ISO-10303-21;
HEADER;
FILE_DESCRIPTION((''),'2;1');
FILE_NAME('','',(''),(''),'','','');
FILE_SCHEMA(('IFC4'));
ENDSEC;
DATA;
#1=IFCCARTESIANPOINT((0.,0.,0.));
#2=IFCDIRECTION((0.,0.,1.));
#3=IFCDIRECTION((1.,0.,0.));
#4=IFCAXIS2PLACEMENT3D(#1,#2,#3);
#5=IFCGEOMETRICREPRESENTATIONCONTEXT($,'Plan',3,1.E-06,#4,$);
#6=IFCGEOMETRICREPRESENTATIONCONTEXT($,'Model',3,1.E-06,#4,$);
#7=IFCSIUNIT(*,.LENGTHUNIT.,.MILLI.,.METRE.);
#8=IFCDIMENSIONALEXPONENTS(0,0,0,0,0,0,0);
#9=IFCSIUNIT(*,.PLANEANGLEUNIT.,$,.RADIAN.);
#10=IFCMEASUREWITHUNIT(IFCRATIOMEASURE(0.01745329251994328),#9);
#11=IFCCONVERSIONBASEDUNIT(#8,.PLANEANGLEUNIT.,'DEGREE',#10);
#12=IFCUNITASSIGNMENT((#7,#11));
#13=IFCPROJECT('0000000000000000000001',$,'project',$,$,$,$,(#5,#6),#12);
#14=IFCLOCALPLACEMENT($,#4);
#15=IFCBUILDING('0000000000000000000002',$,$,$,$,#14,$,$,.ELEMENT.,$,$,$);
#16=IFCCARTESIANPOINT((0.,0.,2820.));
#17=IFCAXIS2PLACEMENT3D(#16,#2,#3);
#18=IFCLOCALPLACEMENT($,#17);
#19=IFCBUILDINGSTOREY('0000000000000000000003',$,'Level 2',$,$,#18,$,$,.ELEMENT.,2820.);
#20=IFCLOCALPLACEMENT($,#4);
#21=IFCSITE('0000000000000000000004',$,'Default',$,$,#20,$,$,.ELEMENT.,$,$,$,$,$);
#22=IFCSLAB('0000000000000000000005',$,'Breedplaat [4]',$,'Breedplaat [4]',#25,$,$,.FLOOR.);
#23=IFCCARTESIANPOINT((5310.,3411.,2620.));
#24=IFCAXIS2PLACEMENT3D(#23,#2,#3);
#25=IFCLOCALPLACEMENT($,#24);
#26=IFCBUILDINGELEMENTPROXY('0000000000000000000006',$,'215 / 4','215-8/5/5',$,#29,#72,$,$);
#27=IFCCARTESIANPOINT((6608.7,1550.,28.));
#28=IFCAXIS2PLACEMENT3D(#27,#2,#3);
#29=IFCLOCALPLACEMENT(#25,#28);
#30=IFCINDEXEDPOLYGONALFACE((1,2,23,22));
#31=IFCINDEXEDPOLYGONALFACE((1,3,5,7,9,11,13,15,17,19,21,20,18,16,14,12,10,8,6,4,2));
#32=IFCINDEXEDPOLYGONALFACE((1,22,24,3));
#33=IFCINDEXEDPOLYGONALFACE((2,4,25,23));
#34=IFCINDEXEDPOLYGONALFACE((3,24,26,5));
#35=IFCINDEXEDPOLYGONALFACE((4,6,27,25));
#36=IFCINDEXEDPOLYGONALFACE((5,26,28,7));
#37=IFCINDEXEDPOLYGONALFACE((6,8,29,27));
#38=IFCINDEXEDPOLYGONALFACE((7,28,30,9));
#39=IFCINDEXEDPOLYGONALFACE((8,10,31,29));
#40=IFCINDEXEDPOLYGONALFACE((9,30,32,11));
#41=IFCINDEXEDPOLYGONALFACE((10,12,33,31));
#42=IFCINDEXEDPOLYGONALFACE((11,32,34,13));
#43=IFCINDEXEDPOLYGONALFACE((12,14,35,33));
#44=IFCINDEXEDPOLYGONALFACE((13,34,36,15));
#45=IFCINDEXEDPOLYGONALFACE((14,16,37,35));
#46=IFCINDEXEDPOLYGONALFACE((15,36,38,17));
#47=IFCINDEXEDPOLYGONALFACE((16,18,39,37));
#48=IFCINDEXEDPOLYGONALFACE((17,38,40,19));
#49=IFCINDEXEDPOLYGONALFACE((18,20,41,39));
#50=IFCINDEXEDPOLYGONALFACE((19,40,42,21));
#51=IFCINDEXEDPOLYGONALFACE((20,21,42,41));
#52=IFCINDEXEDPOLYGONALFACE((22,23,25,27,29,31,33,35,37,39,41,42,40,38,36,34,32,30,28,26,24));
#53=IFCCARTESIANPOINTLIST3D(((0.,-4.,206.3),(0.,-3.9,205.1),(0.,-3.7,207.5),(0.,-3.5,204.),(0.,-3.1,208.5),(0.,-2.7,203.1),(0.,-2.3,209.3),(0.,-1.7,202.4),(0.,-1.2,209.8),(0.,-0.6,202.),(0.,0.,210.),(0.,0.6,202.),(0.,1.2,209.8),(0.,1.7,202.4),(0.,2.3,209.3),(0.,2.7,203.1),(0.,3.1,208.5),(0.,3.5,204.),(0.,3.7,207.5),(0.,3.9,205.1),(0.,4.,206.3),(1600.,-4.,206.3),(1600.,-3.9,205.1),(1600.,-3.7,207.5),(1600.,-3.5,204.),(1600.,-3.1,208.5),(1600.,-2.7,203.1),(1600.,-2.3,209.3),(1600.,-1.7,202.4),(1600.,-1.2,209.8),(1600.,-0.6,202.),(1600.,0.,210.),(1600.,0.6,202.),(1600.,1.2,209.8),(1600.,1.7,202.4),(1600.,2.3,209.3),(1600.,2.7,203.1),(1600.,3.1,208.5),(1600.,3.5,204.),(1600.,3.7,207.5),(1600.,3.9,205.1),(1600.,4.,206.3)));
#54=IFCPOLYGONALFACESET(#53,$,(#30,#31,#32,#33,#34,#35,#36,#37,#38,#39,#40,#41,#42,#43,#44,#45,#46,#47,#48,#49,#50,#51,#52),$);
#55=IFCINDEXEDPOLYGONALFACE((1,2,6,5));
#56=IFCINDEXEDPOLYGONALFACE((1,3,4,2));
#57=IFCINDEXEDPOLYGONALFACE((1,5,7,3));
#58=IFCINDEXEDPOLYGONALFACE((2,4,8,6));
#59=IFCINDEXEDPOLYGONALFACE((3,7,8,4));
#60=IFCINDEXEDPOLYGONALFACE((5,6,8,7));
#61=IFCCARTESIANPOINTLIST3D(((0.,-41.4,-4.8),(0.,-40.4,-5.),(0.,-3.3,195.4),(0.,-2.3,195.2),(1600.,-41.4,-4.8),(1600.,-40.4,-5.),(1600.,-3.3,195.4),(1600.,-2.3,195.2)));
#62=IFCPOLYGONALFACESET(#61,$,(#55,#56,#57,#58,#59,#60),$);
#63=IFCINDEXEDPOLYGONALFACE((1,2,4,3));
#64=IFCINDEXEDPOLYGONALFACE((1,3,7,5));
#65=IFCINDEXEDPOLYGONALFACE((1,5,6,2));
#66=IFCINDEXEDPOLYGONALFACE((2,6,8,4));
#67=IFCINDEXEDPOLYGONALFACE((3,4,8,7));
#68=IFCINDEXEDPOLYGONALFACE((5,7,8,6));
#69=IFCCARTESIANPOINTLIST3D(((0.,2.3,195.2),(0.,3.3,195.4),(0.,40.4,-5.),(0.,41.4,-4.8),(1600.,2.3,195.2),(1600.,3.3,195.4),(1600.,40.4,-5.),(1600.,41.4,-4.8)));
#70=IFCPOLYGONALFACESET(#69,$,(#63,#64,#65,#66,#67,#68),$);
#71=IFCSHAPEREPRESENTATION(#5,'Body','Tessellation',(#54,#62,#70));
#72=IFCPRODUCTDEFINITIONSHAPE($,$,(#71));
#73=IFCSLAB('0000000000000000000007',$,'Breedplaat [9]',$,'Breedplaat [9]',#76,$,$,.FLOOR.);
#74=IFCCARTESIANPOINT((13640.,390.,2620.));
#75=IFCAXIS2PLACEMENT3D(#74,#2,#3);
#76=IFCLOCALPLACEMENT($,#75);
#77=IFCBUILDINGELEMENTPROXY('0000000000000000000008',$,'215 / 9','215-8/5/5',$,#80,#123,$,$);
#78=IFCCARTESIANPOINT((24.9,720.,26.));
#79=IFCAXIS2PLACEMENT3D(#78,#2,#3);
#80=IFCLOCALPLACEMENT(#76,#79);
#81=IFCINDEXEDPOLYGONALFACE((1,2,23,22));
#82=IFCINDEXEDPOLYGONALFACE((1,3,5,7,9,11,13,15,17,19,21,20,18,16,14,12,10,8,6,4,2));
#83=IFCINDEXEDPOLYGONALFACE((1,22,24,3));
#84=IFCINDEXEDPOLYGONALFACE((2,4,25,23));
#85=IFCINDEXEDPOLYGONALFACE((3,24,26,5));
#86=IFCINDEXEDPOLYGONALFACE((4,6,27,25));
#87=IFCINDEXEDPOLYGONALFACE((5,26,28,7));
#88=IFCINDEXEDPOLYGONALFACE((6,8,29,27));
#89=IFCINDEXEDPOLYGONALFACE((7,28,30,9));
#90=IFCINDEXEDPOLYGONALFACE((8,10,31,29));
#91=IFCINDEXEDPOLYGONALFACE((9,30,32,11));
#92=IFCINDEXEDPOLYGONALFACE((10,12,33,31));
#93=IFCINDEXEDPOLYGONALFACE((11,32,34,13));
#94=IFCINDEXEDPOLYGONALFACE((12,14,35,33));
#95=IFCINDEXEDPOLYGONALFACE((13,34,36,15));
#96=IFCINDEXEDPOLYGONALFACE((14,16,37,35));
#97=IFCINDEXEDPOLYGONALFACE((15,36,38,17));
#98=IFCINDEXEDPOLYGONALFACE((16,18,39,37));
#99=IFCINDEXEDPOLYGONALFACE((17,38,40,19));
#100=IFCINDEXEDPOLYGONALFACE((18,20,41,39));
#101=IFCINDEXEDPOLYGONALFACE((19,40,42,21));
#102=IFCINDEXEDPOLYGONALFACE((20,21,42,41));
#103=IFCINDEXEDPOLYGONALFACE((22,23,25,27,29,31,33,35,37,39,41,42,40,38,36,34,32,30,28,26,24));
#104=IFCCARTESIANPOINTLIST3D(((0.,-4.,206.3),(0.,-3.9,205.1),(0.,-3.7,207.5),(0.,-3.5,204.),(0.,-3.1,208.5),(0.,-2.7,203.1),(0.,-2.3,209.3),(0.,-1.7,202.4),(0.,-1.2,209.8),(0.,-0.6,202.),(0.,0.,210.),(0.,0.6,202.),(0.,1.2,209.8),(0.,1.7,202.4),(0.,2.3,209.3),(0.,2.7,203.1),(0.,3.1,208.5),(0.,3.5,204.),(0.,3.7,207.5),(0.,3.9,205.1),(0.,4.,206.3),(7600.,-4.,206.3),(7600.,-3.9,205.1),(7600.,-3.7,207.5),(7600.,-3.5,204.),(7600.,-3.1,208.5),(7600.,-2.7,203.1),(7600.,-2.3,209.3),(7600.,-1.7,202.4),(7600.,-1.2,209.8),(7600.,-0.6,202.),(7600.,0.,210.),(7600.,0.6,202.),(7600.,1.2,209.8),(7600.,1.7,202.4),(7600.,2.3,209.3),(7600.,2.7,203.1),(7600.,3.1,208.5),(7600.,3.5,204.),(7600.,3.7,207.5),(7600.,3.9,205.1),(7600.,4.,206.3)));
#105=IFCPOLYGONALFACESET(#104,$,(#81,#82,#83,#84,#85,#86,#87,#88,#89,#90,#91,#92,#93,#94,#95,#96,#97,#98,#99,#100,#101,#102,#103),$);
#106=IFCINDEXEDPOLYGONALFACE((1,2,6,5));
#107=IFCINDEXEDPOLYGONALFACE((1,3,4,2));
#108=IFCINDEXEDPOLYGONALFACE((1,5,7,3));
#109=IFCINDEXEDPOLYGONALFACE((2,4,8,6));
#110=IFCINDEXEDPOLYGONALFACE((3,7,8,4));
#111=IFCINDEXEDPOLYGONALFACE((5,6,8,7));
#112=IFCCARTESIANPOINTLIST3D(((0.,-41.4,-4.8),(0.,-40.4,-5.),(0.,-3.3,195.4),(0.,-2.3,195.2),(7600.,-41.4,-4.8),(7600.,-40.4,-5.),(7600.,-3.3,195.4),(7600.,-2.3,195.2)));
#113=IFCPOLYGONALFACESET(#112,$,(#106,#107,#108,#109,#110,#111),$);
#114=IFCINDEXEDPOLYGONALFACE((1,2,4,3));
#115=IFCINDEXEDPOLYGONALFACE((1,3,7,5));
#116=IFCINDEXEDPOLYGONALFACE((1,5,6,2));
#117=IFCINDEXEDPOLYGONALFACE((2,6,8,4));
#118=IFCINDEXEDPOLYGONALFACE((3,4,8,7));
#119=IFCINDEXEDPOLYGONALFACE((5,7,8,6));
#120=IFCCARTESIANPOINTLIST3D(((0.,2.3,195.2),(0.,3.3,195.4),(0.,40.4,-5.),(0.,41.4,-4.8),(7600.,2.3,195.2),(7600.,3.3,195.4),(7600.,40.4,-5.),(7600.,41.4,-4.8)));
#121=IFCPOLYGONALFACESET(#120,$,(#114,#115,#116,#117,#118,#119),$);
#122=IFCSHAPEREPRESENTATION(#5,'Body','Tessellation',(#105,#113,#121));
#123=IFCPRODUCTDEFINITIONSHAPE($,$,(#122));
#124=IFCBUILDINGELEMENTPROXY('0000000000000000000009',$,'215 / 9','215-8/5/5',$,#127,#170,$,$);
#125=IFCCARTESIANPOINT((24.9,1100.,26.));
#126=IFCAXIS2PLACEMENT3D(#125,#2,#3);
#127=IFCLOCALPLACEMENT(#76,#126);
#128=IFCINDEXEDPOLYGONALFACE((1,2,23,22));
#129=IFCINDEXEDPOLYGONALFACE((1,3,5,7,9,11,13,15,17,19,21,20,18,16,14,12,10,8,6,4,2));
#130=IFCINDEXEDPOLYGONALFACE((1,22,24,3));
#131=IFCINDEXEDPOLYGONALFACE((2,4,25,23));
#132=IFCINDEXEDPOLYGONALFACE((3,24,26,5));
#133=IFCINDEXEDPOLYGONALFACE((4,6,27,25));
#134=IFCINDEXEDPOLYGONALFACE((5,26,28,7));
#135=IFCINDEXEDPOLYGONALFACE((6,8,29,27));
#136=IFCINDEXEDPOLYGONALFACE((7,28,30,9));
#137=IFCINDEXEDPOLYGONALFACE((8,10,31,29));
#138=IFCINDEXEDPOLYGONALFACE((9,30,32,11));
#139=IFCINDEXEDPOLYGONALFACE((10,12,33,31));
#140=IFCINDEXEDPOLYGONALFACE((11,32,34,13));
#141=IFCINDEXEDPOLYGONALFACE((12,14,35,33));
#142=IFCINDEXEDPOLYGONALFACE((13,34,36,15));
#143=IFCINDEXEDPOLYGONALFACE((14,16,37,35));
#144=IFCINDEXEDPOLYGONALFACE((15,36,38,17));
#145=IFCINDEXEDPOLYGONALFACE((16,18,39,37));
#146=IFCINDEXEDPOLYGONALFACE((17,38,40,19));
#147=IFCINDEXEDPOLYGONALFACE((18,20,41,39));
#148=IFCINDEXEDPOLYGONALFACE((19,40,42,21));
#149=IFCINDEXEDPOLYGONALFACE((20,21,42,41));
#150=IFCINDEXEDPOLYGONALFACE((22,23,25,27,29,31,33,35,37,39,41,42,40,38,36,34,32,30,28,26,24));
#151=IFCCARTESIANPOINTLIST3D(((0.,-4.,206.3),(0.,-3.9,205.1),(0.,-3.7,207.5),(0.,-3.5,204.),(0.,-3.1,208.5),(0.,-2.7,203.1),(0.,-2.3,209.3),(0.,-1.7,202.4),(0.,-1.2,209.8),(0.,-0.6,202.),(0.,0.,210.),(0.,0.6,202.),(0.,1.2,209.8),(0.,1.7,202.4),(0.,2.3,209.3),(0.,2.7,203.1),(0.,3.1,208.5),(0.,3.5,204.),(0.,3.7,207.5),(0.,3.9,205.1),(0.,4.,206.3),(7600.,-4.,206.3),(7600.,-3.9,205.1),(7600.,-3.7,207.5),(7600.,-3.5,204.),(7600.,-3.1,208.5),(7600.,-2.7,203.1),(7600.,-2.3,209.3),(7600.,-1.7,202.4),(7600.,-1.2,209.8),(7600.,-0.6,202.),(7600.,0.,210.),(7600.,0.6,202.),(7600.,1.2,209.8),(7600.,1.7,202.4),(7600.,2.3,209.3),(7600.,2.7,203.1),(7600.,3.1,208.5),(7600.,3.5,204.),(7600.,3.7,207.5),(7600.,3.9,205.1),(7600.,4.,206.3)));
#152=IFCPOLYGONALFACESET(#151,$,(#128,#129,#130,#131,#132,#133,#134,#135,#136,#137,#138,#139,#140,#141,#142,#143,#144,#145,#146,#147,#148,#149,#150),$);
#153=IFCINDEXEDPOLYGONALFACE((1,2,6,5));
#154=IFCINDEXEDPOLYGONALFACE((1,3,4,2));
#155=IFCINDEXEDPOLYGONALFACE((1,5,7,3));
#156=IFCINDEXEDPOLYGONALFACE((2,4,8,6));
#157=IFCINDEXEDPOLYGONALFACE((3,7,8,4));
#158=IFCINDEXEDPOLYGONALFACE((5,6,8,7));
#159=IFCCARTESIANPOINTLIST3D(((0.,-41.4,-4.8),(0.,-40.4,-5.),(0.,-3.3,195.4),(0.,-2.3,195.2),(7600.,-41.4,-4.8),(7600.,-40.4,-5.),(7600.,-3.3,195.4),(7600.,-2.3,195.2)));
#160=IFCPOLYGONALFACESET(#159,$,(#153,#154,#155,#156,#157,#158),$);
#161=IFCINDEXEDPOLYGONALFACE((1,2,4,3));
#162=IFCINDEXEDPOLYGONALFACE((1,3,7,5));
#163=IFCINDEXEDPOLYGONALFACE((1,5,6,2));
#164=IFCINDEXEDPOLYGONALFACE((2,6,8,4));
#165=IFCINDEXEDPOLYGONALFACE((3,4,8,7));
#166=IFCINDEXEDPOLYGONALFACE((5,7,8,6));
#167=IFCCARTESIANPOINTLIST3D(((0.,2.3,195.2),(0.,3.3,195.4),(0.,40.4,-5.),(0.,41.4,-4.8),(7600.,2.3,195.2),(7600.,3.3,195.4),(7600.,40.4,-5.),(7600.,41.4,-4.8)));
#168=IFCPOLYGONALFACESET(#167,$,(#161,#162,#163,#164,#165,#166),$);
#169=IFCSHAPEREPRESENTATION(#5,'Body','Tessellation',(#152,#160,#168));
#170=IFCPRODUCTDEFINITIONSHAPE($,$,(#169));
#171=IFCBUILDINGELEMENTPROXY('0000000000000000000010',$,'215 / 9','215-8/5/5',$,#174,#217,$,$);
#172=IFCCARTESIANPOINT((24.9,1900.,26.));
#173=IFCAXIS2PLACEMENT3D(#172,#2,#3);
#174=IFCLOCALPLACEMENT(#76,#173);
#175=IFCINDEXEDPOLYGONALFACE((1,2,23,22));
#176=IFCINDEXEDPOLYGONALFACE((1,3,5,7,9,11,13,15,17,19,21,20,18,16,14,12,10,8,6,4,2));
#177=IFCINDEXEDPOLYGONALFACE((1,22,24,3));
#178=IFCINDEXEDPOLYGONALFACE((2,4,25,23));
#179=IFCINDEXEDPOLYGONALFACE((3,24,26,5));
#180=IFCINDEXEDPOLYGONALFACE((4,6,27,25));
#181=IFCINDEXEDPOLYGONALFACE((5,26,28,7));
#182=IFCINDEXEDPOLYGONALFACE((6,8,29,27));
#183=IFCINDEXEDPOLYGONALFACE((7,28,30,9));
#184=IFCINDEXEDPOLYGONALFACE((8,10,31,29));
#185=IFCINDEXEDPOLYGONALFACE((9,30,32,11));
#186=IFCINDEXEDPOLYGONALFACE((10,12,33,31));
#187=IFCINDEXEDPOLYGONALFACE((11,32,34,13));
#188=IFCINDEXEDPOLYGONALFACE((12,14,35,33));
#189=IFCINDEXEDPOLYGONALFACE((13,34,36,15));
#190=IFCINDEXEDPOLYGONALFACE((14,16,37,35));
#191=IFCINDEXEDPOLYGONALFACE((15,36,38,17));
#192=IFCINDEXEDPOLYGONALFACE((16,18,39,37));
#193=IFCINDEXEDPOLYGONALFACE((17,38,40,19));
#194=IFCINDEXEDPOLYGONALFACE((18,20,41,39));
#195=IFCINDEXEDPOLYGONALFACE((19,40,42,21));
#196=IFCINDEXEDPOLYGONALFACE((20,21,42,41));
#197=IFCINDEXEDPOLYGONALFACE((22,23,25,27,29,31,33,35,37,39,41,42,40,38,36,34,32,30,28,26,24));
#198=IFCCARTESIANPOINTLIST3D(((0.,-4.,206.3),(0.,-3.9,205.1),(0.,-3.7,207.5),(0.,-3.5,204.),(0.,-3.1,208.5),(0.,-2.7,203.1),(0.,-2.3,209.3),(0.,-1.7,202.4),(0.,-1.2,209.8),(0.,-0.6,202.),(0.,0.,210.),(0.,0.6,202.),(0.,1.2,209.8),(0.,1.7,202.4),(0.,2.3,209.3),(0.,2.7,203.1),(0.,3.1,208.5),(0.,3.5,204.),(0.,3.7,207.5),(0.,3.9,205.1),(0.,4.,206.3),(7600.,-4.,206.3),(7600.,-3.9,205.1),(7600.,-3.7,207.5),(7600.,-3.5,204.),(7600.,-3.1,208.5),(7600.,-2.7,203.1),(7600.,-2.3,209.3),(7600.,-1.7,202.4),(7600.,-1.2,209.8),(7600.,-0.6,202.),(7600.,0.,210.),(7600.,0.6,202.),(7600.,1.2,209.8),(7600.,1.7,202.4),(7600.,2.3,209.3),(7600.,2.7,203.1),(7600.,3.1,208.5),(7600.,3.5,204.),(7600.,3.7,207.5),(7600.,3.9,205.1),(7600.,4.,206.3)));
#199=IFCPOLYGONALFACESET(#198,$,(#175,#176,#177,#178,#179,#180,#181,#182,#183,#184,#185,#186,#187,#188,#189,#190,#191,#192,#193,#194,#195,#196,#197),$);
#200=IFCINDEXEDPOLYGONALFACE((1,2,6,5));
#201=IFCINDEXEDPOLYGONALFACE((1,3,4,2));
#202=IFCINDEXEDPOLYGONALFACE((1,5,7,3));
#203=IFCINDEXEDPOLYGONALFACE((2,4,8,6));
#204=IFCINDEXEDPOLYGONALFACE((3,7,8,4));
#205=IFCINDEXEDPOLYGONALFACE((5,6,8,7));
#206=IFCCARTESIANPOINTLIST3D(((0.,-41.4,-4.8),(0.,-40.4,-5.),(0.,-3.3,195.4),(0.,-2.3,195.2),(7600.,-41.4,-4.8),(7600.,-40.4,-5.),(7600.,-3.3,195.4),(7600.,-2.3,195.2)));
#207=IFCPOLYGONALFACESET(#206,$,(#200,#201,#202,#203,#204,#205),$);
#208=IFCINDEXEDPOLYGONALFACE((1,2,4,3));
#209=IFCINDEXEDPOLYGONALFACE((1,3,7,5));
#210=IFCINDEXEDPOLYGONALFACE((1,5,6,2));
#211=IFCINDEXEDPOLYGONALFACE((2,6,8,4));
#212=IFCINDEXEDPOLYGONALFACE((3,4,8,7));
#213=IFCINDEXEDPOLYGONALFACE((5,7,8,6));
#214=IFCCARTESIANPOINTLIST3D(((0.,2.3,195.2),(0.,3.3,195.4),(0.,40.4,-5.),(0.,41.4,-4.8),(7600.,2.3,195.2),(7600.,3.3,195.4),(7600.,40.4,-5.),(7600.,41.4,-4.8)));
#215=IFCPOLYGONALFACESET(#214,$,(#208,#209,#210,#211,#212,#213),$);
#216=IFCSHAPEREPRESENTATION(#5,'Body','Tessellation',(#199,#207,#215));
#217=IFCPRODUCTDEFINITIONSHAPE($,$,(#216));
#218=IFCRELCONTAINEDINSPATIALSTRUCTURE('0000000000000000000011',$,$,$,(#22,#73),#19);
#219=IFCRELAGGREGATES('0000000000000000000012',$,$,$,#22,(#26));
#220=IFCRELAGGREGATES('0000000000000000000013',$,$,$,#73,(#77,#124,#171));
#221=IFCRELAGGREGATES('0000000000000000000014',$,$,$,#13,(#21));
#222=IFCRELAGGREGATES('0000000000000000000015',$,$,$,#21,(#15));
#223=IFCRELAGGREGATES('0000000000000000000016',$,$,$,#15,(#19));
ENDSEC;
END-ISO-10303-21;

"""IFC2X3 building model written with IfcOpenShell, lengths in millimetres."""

from ifc_helpers import new_model, entity, si_unit, converted_unit, frame, origin_with_axes, origin_2d_with_axis, place, context, project, spatial, rectangle, circle, extrude, element, aggregate, save


model = new_model("IFC2X3")

# Units and contexts
plan_context = context("Plan", 3, precision=1e-06, world=origin_with_axes())
model_context = context("Model", 3, precision=1e-06, world=origin_with_axes())
ifc_project = project(units=[si_unit("LENGTHUNIT", "METRE", prefix="MILLI"), converted_unit("PLANEANGLEUNIT", "DEGREE", entity("IfcRatioMeasure", 0.01745329251994328), si_unit("PLANEANGLEUNIT", "RADIAN"), dimensions=[0, 0, 0, 0, 0, 0, 0])], contexts=[plan_context, model_context])

# Site, building, storey
site_placement = place(None, origin_with_axes())
site = spatial("IfcSite", under=ifc_project, at=site_placement, Name="Default", CompositionType="ELEMENT")
building_placement = place(None, origin_with_axes())
building = spatial("IfcBuilding", under=site, at=building_placement, CompositionType="ELEMENT")
storey_placement = place(None, frame((0.0, 0.0, 2820.0), z_axis=(0.0, 0.0, 1.0), x_axis=(1.0, 0.0, 0.0)))
storey = spatial("IfcBuildingStorey", under=building, at=storey_placement, Name="Level 2", CompositionType="ELEMENT", Elevation=2820.0)

# Slab, building element proxy
slab_1_placement = place(None, frame((5310.0, 3411.0, 2620.0), z_axis=(0.0, 0.0, 1.0), x_axis=(1.0, 0.0, 0.0)))
slab_1 = element("IfcSlab", 1, at=slab_1_placement, inside=storey, Name="Breedplaat [4]", ObjectType="Breedplaat [4]", PredefinedType="FLOOR")
proxy_1_placement = place(slab_1_placement, frame((6608.7, 1550.0, 28.0), z_axis=(0.0, 0.0, 1.0), x_axis=(1.0, 0.0, 0.0)))
proxy_1 = element("IfcBuildingElementProxy", 2, at=proxy_1_placement, Name="215 / 4", Description="215-8/5/5", context=plan_context, shape_type="SweptSolid", body=[
    extrude(circle(Radius=4.0, at=origin_2d_with_axis()), frame((0.0, 0.0, 206.0), z_axis=(1.0, 0.0, 0.0), x_axis=(0.0, 0.0, 1.0)), (0.0, 0.0, 1.0), 1600.0),
    extrude(rectangle(XDim=203.8, YDim=1.0, at=origin_2d_with_axis()), frame((0.0, -21.9, 95.2), z_axis=(1.0, 0.0, 0.0), x_axis=(0.0, 0.187112, 0.982339)), (0.0, 0.0, 1.0), 1600.0),
    extrude(rectangle(XDim=203.8, YDim=1.0, at=origin_2d_with_axis()), frame((0.0, 21.9, 95.2), z_axis=(1.0, 0.0, 0.0), x_axis=(0.0, -0.187112, 0.982339)), (0.0, 0.0, 1.0), 1600.0),
])
aggregate(slab_1, [proxy_1])

# Slab, building element proxies
slab_2_placement = place(None, frame((13640.0, 390.0, 2620.0), z_axis=(0.0, 0.0, 1.0), x_axis=(1.0, 0.0, 0.0)))
slab_2 = element("IfcSlab", 3, at=slab_2_placement, inside=storey, Name="Breedplaat [9]", ObjectType="Breedplaat [9]", PredefinedType="FLOOR")
proxy_2_placement = place(slab_2_placement, frame((24.9, 720.0, 26.0), z_axis=(0.0, 0.0, 1.0), x_axis=(1.0, 0.0, 0.0)))
proxy_2 = element("IfcBuildingElementProxy", 4, at=proxy_2_placement, Name="215 / 9", Description="215-8/5/5", context=plan_context, shape_type="SweptSolid", body=[
    extrude(circle(Radius=4.0, at=origin_2d_with_axis()), frame((0.0, 0.0, 206.0), z_axis=(1.0, 0.0, 0.0), x_axis=(0.0, 0.0, 1.0)), (0.0, 0.0, 1.0), 7600.0),
    extrude(rectangle(XDim=203.8, YDim=1.0, at=origin_2d_with_axis()), frame((0.0, -21.9, 95.2), z_axis=(1.0, 0.0, 0.0), x_axis=(0.0, 0.187112, 0.982339)), (0.0, 0.0, 1.0), 7600.0),
    extrude(rectangle(XDim=203.8, YDim=1.0, at=origin_2d_with_axis()), frame((0.0, 21.9, 95.2), z_axis=(1.0, 0.0, 0.0), x_axis=(0.0, -0.187112, 0.982339)), (0.0, 0.0, 1.0), 7600.0),
])
proxy_3_placement = place(slab_2_placement, frame((24.9, 1100.0, 26.0), z_axis=(0.0, 0.0, 1.0), x_axis=(1.0, 0.0, 0.0)))
proxy_3 = element("IfcBuildingElementProxy", 5, at=proxy_3_placement, Name="215 / 9", Description="215-8/5/5", context=plan_context, shape_type="SweptSolid", body=[
    extrude(circle(Radius=4.0, at=origin_2d_with_axis()), frame((0.0, 0.0, 206.0), z_axis=(1.0, 0.0, 0.0), x_axis=(0.0, 0.0, 1.0)), (0.0, 0.0, 1.0), 7600.0),
    extrude(rectangle(XDim=203.8, YDim=1.0, at=origin_2d_with_axis()), frame((0.0, -21.9, 95.2), z_axis=(1.0, 0.0, 0.0), x_axis=(0.0, 0.187112, 0.982339)), (0.0, 0.0, 1.0), 7600.0),
    extrude(rectangle(XDim=203.8, YDim=1.0, at=origin_2d_with_axis()), frame((0.0, 21.9, 95.2), z_axis=(1.0, 0.0, 0.0), x_axis=(0.0, -0.187112, 0.982339)), (0.0, 0.0, 1.0), 7600.0),
])
proxy_4_placement = place(slab_2_placement, frame((24.9, 1900.0, 26.0), z_axis=(0.0, 0.0, 1.0), x_axis=(1.0, 0.0, 0.0)))
proxy_4 = element("IfcBuildingElementProxy", 6, at=proxy_4_placement, Name="215 / 9", Description="215-8/5/5", context=plan_context, shape_type="SweptSolid", body=[
    extrude(circle(Radius=4.0, at=origin_2d_with_axis()), frame((0.0, 0.0, 206.0), z_axis=(1.0, 0.0, 0.0), x_axis=(0.0, 0.0, 1.0)), (0.0, 0.0, 1.0), 7600.0),
    extrude(rectangle(XDim=203.8, YDim=1.0, at=origin_2d_with_axis()), frame((0.0, -21.9, 95.2), z_axis=(1.0, 0.0, 0.0), x_axis=(0.0, 0.187112, 0.982339)), (0.0, 0.0, 1.0), 7600.0),
    extrude(rectangle(XDim=203.8, YDim=1.0, at=origin_2d_with_axis()), frame((0.0, 21.9, 95.2), z_axis=(1.0, 0.0, 0.0), x_axis=(0.0, -0.187112, 0.982339)), (0.0, 0.0, 1.0), 7600.0),
])
aggregate(slab_2, [proxy_2, proxy_3, proxy_4])

save(model, "model.ifc")
